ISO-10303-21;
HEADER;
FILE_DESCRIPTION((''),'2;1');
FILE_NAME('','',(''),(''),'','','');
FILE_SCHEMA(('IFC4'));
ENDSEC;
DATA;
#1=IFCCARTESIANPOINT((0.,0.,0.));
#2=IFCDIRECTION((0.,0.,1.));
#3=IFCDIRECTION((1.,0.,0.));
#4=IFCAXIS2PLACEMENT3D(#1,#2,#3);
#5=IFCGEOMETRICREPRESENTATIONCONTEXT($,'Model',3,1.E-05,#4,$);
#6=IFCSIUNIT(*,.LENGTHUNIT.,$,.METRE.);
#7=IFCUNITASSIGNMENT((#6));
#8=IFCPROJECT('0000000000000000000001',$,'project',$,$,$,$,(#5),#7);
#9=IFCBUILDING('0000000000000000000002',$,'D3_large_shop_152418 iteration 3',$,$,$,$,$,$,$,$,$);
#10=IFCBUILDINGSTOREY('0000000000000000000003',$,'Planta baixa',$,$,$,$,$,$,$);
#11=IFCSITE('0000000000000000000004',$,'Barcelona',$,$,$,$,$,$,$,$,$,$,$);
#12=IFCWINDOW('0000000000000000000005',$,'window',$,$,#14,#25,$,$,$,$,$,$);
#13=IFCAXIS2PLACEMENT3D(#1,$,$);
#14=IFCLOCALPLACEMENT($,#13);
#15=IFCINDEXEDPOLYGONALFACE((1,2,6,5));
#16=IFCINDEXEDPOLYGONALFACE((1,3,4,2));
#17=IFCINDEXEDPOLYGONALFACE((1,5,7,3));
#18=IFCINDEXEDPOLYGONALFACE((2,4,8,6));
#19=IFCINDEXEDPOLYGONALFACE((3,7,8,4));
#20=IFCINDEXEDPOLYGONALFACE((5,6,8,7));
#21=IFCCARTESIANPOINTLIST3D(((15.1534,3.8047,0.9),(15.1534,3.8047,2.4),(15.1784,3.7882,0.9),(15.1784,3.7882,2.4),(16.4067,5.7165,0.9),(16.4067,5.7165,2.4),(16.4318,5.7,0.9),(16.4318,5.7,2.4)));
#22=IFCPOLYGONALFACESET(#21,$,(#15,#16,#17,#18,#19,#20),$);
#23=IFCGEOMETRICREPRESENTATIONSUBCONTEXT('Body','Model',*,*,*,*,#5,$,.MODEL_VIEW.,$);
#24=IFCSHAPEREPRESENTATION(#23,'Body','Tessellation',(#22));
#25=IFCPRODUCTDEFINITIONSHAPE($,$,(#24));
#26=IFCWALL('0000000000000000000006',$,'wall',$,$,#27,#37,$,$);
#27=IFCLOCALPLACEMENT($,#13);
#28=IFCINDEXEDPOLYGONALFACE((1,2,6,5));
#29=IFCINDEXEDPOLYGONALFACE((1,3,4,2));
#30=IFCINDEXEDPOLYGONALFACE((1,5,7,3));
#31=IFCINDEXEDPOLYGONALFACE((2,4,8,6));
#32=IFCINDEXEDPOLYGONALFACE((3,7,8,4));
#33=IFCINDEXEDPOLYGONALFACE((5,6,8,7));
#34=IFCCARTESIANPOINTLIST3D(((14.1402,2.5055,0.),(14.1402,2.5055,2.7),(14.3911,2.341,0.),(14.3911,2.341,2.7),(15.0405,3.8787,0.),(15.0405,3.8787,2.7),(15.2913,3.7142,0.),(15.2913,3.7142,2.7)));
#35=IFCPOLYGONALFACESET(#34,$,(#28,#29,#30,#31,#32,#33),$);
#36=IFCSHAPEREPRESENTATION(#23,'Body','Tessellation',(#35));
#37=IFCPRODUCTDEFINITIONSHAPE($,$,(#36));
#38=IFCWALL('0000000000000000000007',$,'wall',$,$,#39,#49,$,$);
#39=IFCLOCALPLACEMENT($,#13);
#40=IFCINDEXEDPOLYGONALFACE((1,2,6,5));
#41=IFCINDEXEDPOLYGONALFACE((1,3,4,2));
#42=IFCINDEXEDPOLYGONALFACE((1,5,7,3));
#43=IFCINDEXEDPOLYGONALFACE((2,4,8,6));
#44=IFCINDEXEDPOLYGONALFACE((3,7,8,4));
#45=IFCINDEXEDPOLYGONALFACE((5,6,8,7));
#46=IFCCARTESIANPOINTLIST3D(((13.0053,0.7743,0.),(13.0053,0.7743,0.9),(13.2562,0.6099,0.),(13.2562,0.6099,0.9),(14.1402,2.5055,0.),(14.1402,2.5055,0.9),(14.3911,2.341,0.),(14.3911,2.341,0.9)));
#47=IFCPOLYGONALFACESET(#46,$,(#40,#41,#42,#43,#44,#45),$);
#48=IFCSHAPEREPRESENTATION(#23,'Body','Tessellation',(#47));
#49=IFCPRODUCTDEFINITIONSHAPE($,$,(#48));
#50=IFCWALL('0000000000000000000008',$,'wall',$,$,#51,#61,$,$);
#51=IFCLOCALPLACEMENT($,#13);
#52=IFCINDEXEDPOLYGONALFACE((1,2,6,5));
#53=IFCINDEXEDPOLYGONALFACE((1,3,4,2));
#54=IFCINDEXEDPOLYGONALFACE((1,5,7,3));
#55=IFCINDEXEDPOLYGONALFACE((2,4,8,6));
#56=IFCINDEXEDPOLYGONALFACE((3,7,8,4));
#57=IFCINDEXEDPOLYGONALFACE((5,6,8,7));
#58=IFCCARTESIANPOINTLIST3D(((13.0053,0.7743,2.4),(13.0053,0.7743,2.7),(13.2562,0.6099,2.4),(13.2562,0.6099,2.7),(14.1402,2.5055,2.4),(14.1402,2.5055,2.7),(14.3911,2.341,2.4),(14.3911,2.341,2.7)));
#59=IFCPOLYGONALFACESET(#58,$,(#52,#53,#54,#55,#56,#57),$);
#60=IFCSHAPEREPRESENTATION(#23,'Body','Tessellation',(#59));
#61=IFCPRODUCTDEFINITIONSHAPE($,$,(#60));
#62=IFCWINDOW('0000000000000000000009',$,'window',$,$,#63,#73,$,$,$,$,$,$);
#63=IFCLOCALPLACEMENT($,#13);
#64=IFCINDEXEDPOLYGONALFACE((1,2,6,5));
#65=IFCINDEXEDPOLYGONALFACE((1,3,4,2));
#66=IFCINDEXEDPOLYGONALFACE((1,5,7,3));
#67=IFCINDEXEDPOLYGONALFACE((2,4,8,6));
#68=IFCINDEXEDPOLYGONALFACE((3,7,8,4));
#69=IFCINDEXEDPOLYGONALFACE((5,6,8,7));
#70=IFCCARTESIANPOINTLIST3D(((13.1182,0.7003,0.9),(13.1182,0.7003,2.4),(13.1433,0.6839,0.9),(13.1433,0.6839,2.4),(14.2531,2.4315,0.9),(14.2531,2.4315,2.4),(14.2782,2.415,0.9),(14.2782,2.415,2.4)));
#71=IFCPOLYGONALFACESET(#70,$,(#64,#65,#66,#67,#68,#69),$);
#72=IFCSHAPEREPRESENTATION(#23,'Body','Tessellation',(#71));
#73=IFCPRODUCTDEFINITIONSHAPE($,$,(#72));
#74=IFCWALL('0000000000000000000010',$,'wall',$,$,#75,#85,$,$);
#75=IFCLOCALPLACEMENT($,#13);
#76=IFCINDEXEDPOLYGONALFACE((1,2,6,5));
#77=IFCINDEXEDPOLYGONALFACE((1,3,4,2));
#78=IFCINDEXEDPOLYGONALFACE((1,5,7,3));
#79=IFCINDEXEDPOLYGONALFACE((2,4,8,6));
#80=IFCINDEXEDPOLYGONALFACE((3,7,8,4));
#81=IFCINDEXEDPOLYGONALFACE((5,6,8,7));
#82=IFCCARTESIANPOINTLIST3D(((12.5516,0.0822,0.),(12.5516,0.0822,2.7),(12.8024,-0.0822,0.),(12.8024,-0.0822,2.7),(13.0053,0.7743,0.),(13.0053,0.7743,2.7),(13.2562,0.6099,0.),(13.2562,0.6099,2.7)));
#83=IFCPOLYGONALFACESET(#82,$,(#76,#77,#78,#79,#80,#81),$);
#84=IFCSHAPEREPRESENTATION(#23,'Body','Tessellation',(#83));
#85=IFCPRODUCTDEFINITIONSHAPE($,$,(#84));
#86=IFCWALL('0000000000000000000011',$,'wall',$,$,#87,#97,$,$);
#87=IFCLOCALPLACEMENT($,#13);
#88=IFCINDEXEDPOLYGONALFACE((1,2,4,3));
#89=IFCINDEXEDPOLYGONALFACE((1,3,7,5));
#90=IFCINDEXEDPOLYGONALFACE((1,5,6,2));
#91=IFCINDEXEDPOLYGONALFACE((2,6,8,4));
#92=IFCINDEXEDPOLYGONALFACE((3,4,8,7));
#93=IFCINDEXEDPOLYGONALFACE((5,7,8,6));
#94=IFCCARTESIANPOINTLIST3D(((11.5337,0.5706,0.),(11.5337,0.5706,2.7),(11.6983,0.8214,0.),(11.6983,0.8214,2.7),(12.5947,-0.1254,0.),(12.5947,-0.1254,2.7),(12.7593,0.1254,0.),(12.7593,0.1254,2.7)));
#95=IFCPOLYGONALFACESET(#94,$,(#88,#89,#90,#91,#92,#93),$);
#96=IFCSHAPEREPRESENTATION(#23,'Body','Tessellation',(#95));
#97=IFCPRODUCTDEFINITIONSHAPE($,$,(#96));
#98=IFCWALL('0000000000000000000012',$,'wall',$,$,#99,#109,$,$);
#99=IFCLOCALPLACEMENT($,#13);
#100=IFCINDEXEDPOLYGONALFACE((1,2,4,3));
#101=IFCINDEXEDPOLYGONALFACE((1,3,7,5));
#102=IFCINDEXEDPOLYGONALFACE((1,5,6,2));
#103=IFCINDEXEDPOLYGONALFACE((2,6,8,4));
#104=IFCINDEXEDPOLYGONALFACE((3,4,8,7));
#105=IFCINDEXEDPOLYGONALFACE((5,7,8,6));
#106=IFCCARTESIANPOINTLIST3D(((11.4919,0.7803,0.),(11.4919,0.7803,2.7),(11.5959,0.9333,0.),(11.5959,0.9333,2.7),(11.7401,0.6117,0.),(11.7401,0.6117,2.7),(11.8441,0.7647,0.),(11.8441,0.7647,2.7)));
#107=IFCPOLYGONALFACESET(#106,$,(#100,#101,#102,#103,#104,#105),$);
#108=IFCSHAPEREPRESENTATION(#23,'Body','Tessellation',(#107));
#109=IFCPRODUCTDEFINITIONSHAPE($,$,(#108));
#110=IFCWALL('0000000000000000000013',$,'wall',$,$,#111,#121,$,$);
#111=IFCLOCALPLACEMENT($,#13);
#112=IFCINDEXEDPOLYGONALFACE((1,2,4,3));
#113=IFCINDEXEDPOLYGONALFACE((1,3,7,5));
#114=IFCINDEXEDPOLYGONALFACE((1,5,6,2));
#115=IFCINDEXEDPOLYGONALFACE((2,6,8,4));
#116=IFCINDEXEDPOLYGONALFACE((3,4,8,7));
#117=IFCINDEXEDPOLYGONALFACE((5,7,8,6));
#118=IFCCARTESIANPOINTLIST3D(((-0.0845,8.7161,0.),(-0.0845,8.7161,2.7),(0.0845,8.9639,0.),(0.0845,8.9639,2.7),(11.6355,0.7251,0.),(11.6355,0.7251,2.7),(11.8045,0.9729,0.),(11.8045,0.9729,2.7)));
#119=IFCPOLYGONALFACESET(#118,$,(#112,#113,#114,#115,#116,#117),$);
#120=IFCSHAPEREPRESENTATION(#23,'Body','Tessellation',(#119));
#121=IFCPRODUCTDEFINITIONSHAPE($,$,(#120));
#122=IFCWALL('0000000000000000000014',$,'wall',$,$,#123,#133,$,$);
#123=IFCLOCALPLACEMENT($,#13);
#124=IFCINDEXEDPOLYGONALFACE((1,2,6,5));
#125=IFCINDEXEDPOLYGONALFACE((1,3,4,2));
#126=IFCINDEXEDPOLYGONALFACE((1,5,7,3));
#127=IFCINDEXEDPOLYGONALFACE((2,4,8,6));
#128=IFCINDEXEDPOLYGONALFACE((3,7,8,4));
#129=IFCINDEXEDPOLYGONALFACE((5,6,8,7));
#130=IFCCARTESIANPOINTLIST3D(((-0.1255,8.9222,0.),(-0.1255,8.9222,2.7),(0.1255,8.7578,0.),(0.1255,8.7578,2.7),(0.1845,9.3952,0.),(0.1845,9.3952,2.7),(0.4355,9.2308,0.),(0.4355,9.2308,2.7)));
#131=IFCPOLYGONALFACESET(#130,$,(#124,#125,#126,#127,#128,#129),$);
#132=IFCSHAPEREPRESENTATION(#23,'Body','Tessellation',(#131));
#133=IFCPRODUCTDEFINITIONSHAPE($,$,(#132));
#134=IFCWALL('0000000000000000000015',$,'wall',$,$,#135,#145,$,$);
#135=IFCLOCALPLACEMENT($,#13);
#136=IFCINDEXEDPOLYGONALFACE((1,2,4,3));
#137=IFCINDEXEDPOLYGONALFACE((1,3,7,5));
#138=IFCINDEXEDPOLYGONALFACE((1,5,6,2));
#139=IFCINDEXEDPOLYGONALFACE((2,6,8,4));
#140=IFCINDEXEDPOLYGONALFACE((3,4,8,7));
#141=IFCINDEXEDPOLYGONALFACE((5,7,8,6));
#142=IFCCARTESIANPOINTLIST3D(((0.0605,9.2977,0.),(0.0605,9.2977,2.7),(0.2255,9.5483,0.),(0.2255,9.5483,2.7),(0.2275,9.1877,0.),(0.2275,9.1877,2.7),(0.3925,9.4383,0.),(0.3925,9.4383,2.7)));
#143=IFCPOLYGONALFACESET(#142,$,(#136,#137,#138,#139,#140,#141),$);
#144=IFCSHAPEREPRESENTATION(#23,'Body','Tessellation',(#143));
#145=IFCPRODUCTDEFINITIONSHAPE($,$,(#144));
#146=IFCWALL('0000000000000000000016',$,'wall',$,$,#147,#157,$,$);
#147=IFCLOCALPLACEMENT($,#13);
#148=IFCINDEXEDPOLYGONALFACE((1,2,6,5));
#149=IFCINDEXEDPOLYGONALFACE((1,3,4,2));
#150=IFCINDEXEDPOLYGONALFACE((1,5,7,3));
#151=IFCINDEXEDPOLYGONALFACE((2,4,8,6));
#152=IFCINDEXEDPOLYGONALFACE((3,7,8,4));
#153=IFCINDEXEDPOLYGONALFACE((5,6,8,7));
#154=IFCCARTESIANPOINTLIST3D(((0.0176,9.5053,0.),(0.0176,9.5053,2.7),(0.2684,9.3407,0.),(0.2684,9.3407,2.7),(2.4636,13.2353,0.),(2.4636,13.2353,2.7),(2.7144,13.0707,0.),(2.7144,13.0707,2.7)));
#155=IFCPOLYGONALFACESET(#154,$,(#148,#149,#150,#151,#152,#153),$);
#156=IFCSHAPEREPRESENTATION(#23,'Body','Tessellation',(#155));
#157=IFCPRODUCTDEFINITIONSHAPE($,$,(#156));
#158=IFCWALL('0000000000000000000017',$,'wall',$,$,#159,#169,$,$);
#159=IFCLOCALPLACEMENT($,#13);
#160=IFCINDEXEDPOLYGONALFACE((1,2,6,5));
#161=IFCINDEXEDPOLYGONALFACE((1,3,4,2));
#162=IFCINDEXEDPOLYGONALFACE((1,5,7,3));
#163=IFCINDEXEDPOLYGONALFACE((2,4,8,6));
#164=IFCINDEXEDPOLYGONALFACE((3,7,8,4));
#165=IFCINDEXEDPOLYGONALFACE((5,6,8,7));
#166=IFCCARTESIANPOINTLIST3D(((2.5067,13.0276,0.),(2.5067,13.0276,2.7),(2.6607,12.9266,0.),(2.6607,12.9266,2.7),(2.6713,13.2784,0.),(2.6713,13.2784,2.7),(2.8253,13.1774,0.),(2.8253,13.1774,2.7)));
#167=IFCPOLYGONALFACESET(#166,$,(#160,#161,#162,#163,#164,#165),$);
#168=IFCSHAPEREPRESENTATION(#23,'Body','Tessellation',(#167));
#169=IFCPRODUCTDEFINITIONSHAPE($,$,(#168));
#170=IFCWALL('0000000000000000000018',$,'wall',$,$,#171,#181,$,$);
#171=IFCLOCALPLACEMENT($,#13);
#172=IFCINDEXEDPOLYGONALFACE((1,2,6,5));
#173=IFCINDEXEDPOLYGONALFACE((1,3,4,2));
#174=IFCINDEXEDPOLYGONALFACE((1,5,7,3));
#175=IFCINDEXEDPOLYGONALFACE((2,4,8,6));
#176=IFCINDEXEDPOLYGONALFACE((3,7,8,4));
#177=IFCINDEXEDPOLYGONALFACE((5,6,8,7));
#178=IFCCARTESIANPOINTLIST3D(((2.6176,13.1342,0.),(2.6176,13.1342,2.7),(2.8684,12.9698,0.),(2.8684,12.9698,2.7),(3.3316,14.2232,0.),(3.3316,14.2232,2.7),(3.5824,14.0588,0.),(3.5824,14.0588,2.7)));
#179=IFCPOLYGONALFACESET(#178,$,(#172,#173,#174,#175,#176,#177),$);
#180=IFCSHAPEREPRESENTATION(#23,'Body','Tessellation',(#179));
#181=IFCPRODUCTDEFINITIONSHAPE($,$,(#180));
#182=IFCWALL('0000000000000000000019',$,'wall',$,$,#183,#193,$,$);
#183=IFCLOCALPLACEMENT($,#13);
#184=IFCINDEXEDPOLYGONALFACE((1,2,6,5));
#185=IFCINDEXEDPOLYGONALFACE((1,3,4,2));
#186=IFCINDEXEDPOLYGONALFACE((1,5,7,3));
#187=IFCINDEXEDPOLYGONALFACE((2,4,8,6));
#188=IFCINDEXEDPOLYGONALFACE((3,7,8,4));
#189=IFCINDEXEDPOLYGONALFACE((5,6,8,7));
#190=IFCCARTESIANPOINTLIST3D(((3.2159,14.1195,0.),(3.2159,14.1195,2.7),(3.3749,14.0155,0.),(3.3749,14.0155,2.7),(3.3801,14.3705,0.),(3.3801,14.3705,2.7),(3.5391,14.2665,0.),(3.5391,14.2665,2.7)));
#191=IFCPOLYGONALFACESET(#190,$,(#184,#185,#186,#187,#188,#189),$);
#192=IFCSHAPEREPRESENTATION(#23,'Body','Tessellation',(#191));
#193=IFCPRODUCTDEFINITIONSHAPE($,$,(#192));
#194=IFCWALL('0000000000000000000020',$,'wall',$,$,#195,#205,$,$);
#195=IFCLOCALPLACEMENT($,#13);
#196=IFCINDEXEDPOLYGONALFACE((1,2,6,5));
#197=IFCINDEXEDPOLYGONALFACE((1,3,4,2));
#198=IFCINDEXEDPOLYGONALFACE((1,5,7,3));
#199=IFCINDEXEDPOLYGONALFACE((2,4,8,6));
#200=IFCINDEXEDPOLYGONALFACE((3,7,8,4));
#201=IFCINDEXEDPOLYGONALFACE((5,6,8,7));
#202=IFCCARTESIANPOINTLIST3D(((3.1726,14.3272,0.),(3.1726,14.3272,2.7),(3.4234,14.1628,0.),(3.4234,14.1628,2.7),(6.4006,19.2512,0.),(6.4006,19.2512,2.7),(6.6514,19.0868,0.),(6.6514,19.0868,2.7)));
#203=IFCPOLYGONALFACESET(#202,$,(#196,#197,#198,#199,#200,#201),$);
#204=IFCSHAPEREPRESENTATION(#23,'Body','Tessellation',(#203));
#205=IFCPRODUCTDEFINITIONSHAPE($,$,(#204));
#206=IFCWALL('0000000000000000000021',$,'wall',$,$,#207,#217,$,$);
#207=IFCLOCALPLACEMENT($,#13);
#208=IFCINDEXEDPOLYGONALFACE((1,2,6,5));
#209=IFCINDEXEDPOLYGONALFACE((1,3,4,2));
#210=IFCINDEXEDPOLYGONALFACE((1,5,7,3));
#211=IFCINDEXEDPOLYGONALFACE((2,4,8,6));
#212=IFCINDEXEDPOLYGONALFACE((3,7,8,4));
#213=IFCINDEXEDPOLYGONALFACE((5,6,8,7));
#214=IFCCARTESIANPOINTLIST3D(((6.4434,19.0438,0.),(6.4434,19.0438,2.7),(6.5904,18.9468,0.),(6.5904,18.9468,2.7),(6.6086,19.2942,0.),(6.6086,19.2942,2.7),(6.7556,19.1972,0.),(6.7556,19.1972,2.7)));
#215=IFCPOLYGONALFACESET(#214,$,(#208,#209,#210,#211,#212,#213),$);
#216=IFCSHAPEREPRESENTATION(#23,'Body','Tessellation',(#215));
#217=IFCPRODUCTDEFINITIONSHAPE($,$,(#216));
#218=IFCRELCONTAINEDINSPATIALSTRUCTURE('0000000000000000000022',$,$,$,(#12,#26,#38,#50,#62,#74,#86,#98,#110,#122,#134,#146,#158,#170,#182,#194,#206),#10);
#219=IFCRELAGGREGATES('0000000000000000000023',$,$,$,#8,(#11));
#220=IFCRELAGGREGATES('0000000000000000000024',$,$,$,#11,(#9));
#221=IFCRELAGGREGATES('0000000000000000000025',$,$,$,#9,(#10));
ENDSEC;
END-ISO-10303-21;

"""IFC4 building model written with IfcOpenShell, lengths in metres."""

from ifc_helpers import new_model, si_unit, frame, origin, origin_with_axes, place, context, subcontext, project, spatial, polyline, outline, extrude, element, save


model = new_model("IFC4")

# Units and contexts
model_context = context("Model", 3, precision=1e-05, world=origin_with_axes())
body_context = subcontext(model_context, "Body", "Model", "MODEL_VIEW")
ifc_project = project(units=[si_unit("LENGTHUNIT", "METRE")], contexts=[model_context])

# Site, building, storey
site = spatial("IfcSite", under=ifc_project, Name="Barcelona")
building = spatial("IfcBuilding", under=site, Name="D3_large_shop_152418 iteration 3")
storey = spatial("IfcBuildingStorey", under=building, Name="Planta baixa")

# Window
window_1_placement = place(None, origin_with_axes())
element("IfcWindow", 1, at=window_1_placement, inside=storey, Name="window", context=body_context, shape_type="SweptSolid", body=[
    extrude(outline(polyline([(16.4318, 5.7), (15.1784, 3.7882), (15.1534, 3.8047), (16.4067, 5.7165), (16.4318, 5.7)])), frame((0.0, 0.0, 0.9)), (0.0, 0.0, 1.0), 1.5),
])

# Walls
wall_1_placement = place(None, origin_with_axes())
element("IfcWall", 2, at=wall_1_placement, inside=storey, Name="wall", context=body_context, shape_type="SweptSolid", body=[
    extrude(outline(polyline([(15.2913, 3.7142), (14.3911, 2.341), (14.1402, 2.5055), (15.0405, 3.8787), (15.2913, 3.7142)])), origin(), (0.0, 0.0, 1.0), 2.7),
])
wall_2_placement = place(None, origin_with_axes())
element("IfcWall", 3, at=wall_2_placement, inside=storey, Name="wall", context=body_context, shape_type="SweptSolid", body=[
    extrude(outline(polyline([(14.3911, 2.341), (13.2562, 0.6099), (13.0053, 0.7743), (14.1402, 2.5055), (14.3911, 2.341)])), origin(), (0.0, 0.0, 1.0), 0.9),
])
wall_3_placement = place(None, origin_with_axes())
element("IfcWall", 4, at=wall_3_placement, inside=storey, Name="wall", context=body_context, shape_type="SweptSolid", body=[
    extrude(outline(polyline([(14.3911, 2.341), (13.2562, 0.6099), (13.0053, 0.7743), (14.1402, 2.5055), (14.3911, 2.341)])), frame((0.0, 0.0, 2.4)), (0.0, 0.0, 1.0), 0.3),
])

# Window
window_2_placement = place(None, origin_with_axes())
element("IfcWindow", 5, at=window_2_placement, inside=storey, Name="window", context=body_context, shape_type="SweptSolid", body=[
    extrude(outline(polyline([(14.2782, 2.415), (13.1433, 0.6839), (13.1182, 0.7003), (14.2531, 2.4315), (14.2782, 2.415)])), frame((0.0, 0.0, 0.9)), (0.0, 0.0, 1.0), 1.5),
])

# Walls
wall_4_placement = place(None, origin_with_axes())
element("IfcWall", 6, at=wall_4_placement, inside=storey, Name="wall", context=body_context, shape_type="SweptSolid", body=[
    extrude(outline(polyline([(13.2562, 0.6099), (12.8024, -0.0822), (12.5516, 0.0822), (13.0053, 0.7743), (13.2562, 0.6099)])), origin(), (0.0, 0.0, 1.0), 2.7),
])
wall_5_placement = place(None, origin_with_axes())
element("IfcWall", 7, at=wall_5_placement, inside=storey, Name="wall", context=body_context, shape_type="SweptSolid", body=[
    extrude(outline(polyline([(12.5947, -0.1254), (11.5337, 0.5706), (11.6983, 0.8214), (12.7593, 0.1254), (12.5947, -0.1254)])), origin(), (0.0, 0.0, 1.0), 2.7),
])
wall_6_placement = place(None, origin_with_axes())
element("IfcWall", 8, at=wall_6_placement, inside=storey, Name="wall", context=body_context, shape_type="SweptSolid", body=[
    extrude(outline(polyline([(11.4919, 0.7803), (11.5959, 0.9333), (11.8441, 0.7647), (11.7401, 0.6117), (11.4919, 0.7803)])), origin(), (0.0, 0.0, 1.0), 2.7),
])
wall_7_placement = place(None, origin_with_axes())
element("IfcWall", 9, at=wall_7_placement, inside=storey, Name="wall", context=body_context, shape_type="SweptSolid", body=[
    extrude(outline(polyline([(11.6355, 0.7251), (-0.0845, 8.7161), (0.0845, 8.9639), (11.8045, 0.9729), (11.6355, 0.7251)])), origin(), (0.0, 0.0, 1.0), 2.7),
])
wall_8_placement = place(None, origin_with_axes())
element("IfcWall", 10, at=wall_8_placement, inside=storey, Name="wall", context=body_context, shape_type="SweptSolid", body=[
    extrude(outline(polyline([(-0.1255, 8.9222), (0.1845, 9.3952), (0.4355, 9.2308), (0.1255, 8.7578), (-0.1255, 8.9222)])), origin(), (0.0, 0.0, 1.0), 2.7),
])
wall_9_placement = place(None, origin_with_axes())
element("IfcWall", 11, at=wall_9_placement, inside=storey, Name="wall", context=body_context, shape_type="SweptSolid", body=[
    extrude(outline(polyline([(0.2275, 9.1877), (0.0605, 9.2977), (0.2255, 9.5483), (0.3925, 9.4383), (0.2275, 9.1877)])), origin(), (0.0, 0.0, 1.0), 2.7),
])
wall_10_placement = place(None, origin_with_axes())
element("IfcWall", 12, at=wall_10_placement, inside=storey, Name="wall", context=body_context, shape_type="SweptSolid", body=[
    extrude(outline(polyline([(0.0176, 9.5053), (2.4636, 13.2353), (2.7144, 13.0707), (0.2684, 9.3407), (0.0176, 9.5053)])), origin(), (0.0, 0.0, 1.0), 2.7),
])
wall_11_placement = place(None, origin_with_axes())
element("IfcWall", 13, at=wall_11_placement, inside=storey, Name="wall", context=body_context, shape_type="SweptSolid", body=[
    extrude(outline(polyline([(2.6713, 13.2784), (2.8253, 13.1774), (2.6607, 12.9266), (2.5067, 13.0276), (2.6713, 13.2784)])), origin(), (0.0, 0.0, 1.0), 2.7),
])
wall_12_placement = place(None, origin_with_axes())
element("IfcWall", 14, at=wall_12_placement, inside=storey, Name="wall", context=body_context, shape_type="SweptSolid", body=[
    extrude(outline(polyline([(2.6176, 13.1342), (3.3316, 14.2232), (3.5824, 14.0588), (2.8684, 12.9698), (2.6176, 13.1342)])), origin(), (0.0, 0.0, 1.0), 2.7),
])
wall_13_placement = place(None, origin_with_axes())
element("IfcWall", 15, at=wall_13_placement, inside=storey, Name="wall", context=body_context, shape_type="SweptSolid", body=[
    extrude(outline(polyline([(3.3749, 14.0155), (3.2159, 14.1195), (3.3801, 14.3705), (3.5391, 14.2665), (3.3749, 14.0155)])), origin(), (0.0, 0.0, 1.0), 2.7),
])
wall_14_placement = place(None, origin_with_axes())
element("IfcWall", 16, at=wall_14_placement, inside=storey, Name="wall", context=body_context, shape_type="SweptSolid", body=[
    extrude(outline(polyline([(3.1726, 14.3272), (6.4006, 19.2512), (6.6514, 19.0868), (3.4234, 14.1628), (3.1726, 14.3272)])), origin(), (0.0, 0.0, 1.0), 2.7),
])
wall_15_placement = place(None, origin_with_axes())
element("IfcWall", 17, at=wall_15_placement, inside=storey, Name="wall", context=body_context, shape_type="SweptSolid", body=[
    extrude(outline(polyline([(6.6086, 19.2942), (6.7556, 19.1972), (6.5904, 18.9468), (6.4434, 19.0438), (6.6086, 19.2942)])), origin(), (0.0, 0.0, 1.0), 2.7),
])

save(model, "model.ifc")
